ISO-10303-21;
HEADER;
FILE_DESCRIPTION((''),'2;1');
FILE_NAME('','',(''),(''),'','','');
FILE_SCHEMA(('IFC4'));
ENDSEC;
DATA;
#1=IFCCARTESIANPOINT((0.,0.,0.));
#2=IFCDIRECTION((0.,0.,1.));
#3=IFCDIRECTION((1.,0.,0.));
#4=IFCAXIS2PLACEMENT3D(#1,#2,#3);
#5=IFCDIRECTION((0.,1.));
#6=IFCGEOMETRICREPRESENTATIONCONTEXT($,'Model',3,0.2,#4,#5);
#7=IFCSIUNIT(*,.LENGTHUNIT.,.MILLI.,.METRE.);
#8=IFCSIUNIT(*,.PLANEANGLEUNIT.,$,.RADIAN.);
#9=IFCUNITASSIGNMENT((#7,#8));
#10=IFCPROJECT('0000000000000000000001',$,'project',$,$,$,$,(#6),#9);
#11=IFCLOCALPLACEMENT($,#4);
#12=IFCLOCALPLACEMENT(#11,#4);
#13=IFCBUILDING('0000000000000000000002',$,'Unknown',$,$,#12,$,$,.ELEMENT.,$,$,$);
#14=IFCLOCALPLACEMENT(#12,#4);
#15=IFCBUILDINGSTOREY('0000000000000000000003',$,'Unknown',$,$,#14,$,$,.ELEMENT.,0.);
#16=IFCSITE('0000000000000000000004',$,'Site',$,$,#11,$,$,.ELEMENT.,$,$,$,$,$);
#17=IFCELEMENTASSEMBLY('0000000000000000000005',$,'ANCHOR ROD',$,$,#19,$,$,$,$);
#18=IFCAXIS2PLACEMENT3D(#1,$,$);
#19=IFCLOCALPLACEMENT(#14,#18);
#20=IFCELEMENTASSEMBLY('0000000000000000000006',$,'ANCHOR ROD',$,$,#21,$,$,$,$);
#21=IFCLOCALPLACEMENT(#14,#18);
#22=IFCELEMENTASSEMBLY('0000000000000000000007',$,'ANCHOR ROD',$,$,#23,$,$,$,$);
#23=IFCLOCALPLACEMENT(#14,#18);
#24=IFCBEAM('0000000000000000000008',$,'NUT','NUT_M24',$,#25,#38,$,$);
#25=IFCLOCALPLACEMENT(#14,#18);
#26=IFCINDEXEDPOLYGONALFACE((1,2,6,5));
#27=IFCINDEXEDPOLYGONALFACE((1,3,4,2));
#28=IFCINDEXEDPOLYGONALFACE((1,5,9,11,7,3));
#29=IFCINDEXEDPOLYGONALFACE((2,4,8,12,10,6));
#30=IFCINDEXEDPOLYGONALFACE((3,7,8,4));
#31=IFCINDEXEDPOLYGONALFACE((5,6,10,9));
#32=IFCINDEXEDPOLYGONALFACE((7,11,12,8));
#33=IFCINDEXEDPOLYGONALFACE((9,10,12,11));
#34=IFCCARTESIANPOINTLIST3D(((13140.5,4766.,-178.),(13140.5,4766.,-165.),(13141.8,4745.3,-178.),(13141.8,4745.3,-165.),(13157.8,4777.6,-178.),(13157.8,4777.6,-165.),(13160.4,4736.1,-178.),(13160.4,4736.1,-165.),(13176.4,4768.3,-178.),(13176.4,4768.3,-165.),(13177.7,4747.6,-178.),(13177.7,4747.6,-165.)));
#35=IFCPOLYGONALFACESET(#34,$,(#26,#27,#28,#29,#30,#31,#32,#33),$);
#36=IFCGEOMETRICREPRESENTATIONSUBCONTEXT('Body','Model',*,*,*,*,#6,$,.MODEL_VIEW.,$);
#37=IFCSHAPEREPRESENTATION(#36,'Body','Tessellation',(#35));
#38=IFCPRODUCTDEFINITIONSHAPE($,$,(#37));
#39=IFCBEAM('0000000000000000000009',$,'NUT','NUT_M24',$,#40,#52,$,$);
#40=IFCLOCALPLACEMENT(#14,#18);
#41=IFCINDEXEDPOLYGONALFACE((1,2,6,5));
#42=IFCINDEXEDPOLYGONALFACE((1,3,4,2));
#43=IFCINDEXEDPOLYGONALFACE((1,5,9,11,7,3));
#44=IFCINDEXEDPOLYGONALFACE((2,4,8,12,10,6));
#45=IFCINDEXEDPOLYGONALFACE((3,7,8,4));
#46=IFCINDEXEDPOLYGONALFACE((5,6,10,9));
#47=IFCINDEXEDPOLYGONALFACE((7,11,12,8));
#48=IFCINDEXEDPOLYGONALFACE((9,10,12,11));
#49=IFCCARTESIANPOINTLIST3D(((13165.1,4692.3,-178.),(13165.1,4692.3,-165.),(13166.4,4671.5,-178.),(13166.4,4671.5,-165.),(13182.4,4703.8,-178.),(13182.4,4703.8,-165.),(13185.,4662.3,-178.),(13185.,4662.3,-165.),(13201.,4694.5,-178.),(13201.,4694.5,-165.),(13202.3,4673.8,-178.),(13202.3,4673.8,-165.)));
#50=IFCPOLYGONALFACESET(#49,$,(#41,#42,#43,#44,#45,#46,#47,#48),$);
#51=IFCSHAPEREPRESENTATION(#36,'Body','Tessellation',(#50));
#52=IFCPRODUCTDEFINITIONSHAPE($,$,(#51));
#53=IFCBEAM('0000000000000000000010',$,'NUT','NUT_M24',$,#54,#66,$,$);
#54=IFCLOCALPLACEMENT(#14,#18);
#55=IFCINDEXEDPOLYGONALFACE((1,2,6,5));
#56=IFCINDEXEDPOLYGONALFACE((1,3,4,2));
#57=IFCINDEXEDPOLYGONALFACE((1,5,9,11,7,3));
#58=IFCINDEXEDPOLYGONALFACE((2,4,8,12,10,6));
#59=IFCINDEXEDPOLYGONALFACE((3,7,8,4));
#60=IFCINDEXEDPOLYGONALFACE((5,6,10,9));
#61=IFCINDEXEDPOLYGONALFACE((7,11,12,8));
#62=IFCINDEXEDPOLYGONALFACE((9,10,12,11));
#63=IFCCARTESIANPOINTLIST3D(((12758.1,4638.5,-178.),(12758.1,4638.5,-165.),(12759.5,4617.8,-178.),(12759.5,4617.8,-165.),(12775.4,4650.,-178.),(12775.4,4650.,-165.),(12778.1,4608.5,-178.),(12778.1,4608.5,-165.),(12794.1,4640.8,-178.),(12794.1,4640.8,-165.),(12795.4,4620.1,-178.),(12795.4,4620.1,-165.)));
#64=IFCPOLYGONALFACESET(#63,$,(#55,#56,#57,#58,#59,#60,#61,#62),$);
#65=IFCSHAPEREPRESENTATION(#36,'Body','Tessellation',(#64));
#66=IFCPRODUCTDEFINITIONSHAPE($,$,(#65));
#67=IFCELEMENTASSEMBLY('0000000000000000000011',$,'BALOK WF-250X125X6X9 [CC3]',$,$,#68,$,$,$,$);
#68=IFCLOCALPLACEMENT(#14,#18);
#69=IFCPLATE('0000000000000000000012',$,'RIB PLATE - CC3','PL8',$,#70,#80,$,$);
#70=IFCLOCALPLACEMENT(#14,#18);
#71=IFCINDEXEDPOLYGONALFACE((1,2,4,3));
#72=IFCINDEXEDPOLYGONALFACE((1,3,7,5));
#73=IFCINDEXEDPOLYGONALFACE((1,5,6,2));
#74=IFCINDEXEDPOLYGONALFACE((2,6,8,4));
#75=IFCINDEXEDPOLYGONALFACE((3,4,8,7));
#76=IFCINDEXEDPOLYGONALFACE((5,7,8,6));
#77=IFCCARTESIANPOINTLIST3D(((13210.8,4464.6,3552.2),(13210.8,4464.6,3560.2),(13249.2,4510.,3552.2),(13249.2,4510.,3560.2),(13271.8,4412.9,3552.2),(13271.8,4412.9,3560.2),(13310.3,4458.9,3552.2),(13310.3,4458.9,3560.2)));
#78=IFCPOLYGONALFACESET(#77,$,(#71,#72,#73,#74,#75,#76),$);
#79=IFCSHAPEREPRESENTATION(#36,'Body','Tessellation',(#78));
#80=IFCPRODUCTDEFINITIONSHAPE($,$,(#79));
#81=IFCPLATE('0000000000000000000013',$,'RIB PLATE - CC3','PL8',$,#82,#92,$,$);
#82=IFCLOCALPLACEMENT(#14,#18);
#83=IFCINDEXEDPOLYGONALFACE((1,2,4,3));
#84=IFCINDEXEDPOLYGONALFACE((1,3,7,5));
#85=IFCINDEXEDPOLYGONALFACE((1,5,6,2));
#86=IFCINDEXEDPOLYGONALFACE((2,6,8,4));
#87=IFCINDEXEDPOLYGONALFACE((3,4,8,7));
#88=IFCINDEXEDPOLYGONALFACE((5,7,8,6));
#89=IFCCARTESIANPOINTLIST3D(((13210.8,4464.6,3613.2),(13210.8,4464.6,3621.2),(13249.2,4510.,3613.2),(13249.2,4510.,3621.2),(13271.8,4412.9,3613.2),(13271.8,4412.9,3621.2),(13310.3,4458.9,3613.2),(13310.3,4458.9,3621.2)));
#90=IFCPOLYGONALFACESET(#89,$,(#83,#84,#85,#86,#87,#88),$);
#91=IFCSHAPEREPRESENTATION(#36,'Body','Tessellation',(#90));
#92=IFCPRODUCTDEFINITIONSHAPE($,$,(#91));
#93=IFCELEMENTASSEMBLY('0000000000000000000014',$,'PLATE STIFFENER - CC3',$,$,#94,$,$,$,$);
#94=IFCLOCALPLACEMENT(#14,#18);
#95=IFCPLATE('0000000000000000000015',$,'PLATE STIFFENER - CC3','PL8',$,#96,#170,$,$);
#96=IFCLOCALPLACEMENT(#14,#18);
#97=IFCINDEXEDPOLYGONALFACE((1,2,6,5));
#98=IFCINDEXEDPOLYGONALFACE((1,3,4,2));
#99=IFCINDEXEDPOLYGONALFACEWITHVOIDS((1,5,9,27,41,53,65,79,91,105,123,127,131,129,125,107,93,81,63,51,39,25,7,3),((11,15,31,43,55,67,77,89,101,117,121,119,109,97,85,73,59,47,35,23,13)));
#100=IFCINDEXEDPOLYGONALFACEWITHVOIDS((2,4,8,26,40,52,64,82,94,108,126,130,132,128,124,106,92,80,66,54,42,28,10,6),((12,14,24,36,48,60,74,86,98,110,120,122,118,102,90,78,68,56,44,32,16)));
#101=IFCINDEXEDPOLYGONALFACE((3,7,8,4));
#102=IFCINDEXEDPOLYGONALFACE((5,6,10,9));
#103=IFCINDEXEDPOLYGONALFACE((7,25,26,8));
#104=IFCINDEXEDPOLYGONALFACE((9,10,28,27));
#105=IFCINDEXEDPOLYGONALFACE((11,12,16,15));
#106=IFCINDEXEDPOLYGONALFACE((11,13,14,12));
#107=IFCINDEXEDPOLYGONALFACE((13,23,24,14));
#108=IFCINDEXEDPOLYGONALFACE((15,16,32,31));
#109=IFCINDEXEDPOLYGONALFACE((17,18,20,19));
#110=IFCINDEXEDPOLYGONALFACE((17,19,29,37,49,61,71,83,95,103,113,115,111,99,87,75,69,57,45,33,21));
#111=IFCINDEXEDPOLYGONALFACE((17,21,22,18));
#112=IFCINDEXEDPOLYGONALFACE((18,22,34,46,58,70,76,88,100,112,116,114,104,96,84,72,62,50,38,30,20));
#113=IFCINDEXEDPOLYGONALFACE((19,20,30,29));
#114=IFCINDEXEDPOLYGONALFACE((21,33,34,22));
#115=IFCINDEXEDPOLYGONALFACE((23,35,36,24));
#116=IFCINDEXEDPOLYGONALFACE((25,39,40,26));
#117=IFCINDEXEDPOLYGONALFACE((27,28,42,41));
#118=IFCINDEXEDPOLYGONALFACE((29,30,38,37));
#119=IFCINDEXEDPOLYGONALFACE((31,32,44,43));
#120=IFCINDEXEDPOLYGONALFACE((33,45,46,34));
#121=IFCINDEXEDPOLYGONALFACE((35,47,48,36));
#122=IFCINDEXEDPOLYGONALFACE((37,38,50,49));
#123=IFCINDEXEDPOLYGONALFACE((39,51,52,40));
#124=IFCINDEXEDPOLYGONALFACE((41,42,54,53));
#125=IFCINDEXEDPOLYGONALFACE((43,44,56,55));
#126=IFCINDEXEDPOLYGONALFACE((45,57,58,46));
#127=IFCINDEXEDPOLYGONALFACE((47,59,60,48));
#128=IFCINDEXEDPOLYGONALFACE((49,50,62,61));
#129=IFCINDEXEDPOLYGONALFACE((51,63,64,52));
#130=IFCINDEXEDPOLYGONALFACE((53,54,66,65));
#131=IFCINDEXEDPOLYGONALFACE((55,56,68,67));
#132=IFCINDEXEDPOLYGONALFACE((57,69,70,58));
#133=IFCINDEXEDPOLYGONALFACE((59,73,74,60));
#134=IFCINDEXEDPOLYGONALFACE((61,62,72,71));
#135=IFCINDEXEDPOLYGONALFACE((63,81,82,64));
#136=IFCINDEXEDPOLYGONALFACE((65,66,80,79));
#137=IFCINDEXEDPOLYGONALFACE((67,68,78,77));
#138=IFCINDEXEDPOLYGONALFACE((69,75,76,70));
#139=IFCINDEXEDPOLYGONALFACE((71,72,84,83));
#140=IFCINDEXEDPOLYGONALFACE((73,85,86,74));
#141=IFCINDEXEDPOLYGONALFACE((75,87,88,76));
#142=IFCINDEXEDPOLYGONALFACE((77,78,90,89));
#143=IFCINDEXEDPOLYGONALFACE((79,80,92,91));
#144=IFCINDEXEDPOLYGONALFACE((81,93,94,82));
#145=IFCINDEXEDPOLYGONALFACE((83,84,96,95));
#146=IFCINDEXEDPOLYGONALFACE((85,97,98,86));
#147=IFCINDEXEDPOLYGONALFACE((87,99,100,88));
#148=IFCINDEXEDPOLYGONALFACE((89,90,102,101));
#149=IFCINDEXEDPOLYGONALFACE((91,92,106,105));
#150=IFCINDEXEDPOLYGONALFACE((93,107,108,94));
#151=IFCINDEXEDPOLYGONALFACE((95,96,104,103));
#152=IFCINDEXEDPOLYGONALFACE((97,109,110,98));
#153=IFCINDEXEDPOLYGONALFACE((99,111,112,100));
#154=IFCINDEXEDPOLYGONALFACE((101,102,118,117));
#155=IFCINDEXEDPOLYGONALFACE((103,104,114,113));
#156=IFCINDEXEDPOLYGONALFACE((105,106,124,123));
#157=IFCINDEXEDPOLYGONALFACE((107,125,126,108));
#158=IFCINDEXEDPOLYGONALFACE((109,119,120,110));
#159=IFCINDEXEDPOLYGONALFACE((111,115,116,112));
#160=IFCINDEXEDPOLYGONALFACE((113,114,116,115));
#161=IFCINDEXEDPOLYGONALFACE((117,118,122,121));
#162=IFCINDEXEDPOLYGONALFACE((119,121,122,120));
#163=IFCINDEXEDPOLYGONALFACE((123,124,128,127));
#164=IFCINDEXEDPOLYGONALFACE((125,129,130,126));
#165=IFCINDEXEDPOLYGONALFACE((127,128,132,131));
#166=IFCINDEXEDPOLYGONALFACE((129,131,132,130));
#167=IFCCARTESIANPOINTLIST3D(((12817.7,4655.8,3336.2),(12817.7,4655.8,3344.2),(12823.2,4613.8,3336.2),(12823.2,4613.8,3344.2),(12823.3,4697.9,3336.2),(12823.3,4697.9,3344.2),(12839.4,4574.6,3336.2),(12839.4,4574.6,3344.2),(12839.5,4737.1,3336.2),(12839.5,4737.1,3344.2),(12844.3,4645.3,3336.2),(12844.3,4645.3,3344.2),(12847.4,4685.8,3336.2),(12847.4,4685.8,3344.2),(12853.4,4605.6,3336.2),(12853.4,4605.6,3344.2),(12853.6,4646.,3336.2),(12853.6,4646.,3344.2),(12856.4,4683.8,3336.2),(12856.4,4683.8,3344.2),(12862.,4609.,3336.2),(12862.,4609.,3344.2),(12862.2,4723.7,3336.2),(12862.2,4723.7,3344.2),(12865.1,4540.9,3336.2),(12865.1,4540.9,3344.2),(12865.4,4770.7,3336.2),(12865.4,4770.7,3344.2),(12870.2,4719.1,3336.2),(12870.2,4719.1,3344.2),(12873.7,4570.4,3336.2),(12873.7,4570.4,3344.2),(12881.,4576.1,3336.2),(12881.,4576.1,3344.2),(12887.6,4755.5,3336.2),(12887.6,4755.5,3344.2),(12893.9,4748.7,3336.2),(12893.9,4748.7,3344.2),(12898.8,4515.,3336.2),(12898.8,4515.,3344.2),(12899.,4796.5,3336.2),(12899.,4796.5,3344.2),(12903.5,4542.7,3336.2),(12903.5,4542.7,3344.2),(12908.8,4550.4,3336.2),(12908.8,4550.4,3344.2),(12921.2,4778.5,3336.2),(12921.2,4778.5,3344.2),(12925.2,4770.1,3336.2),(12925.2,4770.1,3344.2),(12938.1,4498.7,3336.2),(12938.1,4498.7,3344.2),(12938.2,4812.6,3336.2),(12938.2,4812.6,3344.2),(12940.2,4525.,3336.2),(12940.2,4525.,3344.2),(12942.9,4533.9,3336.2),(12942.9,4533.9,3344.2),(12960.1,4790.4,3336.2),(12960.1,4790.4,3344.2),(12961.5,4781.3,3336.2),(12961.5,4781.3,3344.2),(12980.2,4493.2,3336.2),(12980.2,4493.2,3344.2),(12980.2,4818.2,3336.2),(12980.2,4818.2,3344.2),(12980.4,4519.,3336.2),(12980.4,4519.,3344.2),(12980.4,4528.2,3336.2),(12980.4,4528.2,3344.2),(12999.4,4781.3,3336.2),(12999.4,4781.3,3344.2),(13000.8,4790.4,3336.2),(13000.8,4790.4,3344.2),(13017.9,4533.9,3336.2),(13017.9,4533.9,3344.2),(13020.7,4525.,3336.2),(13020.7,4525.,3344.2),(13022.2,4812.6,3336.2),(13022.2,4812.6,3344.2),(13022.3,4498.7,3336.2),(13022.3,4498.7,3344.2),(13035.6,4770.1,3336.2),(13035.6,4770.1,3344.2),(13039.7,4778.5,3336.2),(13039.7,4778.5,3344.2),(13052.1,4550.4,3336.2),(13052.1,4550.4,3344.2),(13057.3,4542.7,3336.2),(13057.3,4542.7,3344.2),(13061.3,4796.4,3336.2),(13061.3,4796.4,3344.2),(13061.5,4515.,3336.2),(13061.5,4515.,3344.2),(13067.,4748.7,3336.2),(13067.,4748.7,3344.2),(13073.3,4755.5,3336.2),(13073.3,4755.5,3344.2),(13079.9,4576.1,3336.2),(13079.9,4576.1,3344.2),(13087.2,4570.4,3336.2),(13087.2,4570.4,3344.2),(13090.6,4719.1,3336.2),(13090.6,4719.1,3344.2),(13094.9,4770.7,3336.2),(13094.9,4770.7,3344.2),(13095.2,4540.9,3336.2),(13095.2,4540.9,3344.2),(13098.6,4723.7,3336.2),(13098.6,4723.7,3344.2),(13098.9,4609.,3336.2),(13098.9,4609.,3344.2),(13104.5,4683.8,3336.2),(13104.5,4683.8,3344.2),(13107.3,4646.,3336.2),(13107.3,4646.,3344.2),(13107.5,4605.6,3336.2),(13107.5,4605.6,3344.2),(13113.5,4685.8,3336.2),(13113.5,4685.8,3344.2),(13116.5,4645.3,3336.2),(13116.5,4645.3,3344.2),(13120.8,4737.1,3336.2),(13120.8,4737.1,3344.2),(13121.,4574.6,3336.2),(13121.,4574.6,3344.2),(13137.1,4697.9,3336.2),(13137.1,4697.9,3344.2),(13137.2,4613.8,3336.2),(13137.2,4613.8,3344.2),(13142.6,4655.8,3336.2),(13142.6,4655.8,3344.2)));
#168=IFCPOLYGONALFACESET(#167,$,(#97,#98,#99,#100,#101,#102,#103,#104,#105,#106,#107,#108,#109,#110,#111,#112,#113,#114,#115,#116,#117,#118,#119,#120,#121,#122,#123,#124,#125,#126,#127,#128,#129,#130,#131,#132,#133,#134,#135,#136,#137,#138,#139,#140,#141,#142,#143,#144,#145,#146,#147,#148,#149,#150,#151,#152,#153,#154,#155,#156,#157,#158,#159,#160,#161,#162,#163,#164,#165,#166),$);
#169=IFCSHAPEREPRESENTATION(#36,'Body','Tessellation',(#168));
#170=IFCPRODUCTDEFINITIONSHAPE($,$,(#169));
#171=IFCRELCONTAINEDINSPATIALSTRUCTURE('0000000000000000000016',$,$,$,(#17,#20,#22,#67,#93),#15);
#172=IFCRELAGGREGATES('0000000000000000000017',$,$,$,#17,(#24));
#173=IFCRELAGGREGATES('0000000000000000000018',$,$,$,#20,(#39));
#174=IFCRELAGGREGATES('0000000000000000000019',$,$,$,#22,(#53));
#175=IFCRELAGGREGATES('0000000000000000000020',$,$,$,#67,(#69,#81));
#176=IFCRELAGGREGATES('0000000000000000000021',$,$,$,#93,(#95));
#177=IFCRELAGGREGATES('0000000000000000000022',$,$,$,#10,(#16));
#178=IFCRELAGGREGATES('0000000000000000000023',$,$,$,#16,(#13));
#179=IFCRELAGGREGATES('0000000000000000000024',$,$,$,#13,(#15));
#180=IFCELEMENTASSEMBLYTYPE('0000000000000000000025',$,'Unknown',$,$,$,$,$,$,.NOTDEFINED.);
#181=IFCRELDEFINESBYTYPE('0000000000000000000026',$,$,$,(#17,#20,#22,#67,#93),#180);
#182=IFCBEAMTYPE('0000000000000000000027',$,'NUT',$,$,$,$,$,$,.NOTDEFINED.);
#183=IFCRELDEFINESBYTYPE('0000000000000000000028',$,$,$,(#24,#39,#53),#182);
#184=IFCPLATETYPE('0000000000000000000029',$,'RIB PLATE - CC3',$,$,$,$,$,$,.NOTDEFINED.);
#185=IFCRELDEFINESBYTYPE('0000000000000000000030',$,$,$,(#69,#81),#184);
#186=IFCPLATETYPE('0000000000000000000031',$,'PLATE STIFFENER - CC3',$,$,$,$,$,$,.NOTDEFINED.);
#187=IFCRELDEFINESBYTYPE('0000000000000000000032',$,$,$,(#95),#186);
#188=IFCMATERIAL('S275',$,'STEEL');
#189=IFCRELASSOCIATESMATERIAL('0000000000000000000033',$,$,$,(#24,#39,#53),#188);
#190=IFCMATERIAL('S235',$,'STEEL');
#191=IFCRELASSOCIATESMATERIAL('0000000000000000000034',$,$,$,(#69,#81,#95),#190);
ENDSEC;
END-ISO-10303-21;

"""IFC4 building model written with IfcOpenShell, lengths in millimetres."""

from ifc_helpers import new_model, si_unit, direction, frame, origin_with_axes, origin_2d_with_axis, place, context, subcontext, project, spatial, polyline, line, arc, indexed_curve, hollow_circle, outline, extrude, clip, halfspace, material, material_profile, profile_set, profile_usage, type_object, element, aggregate, save


model = new_model("IFC4")

# Units and contexts
model_context = context("Model", 3, precision=0.2, world=origin_with_axes(), true_north=direction((0.0, 1.0)))
body_context = subcontext(model_context, "Body", "Model", "MODEL_VIEW")
ifc_project = project(units=[si_unit("LENGTHUNIT", "METRE", prefix="MILLI"), si_unit("PLANEANGLEUNIT", "RADIAN")], contexts=[model_context])

# Site, building, storey
site_placement = place(None, origin_with_axes())
site = spatial("IfcSite", under=ifc_project, at=site_placement, Name="Site", CompositionType="ELEMENT")
building_placement = place(site_placement, origin_with_axes())
building = spatial("IfcBuilding", under=site, at=building_placement, Name="Unknown", CompositionType="ELEMENT")
storey_placement = place(building_placement, origin_with_axes())
storey = spatial("IfcBuildingStorey", under=building, at=storey_placement, Name="Unknown", CompositionType="ELEMENT", Elevation=0.0)

# Element assemblies
element_assembly_type = type_object("IfcElementAssemblyType", Name="Unknown", PredefinedType="NOTDEFINED")
ifc_material_1 = material(Name="S275", Category="STEEL")
assembly_1_placement = place(storey_placement, frame((13159.1, 4756.8, -151.0), z_axis=(0.447007, 0.894531, 0.0), x_axis=(0.0, 0.0, -1.0)))
assembly_1 = element("IfcElementAssembly", 1, at=assembly_1_placement, inside=storey, type_object=element_assembly_type, Name="ANCHOR ROD")
assembly_2_placement = place(storey_placement, frame((13183.7, 4683.0, -151.0), z_axis=(0.447007, 0.894531, 0.0), x_axis=(0.0, 0.0, -1.0)))
assembly_2 = element("IfcElementAssembly", 2, at=assembly_2_placement, inside=storey, type_object=element_assembly_type, Name="ANCHOR ROD")
assembly_3_placement = place(storey_placement, frame((12776.8, 4629.3, -151.0), z_axis=(-0.447007, -0.894531, 0.0), x_axis=(0.0, 0.0, -1.0)))
assembly_3 = element("IfcElementAssembly", 3, at=assembly_3_placement, inside=storey, type_object=element_assembly_type, Name="ANCHOR ROD")

# Beams
ifc_material_profile_1 = material_profile(ifc_material_1, outline(polyline([(18.0, 10.4), (0.0, 20.8), (-18.0, 10.4), (-18.0, -10.4), (0.0, -20.8), (18.0, -10.4), (18.0, 10.4)])), Name="NUT_M24")
ifc_profile_set_1 = profile_set([ifc_material_profile_1])
ifc_profile_usage_1 = profile_usage(ifc_profile_set_1, cardinal=5)
beam_type_1 = type_object("IfcBeamType", Name="NUT", PredefinedType="NOTDEFINED")
beam_1_placement = place(assembly_1_placement, frame((14.0, 0.0, 0.0), z_axis=(0.0, 0.003454, 0.999994), x_axis=(1.0, 0.0, 0.0)))
beam_1 = element("IfcBeam", 4, at=beam_1_placement, type_object=beam_type_1, material=ifc_profile_usage_1, Name="NUT", Description="NUT_M24", context=body_context, shape_type="SolidModel", body=[
    extrude(outline(polyline([(18.0, 10.4), (0.0, 20.8), (-18.0, 10.4), (-18.0, -10.4), (0.0, -20.8), (18.0, -10.4), (18.0, 10.4)])), frame((0.0, 0.0, 0.0), z_axis=(-1.0, 0.0, 0.0), x_axis=(0.0, 0.0, 1.0)), (0.0, 0.0, -1.0), 13.0),
])
aggregate(assembly_1, [beam_1])
beam_2_placement = place(assembly_2_placement, frame((14.0, 0.0, 0.0), z_axis=(0.0, 0.003454, 0.999994), x_axis=(1.0, 0.0, 0.0)))
beam_2 = element("IfcBeam", 5, at=beam_2_placement, type_object=beam_type_1, material=ifc_profile_usage_1, Name="NUT", Description="NUT_M24", context=body_context, shape_type="SolidModel", body=[
    extrude(outline(polyline([(18.0, 10.4), (0.0, 20.8), (-18.0, 10.4), (-18.0, -10.4), (0.0, -20.8), (18.0, -10.4), (18.0, 10.4)])), frame((0.0, 0.0, 0.0), z_axis=(-1.0, 0.0, 0.0), x_axis=(0.0, 0.0, 1.0)), (0.0, 0.0, -1.0), 13.0),
])
aggregate(assembly_2, [beam_2])
beam_3_placement = place(assembly_3_placement, frame((14.0, 0.0, 0.0), z_axis=(0.0, -0.003454, -0.999994), x_axis=(1.0, 0.0, 0.0)))
beam_3 = element("IfcBeam", 6, at=beam_3_placement, type_object=beam_type_1, material=ifc_profile_usage_1, Name="NUT", Description="NUT_M24", context=body_context, shape_type="SolidModel", body=[
    extrude(outline(polyline([(18.0, 10.4), (0.0, 20.8), (-18.0, 10.4), (-18.0, -10.4), (0.0, -20.8), (18.0, -10.4), (18.0, 10.4)])), frame((0.0, 0.0, 0.0), z_axis=(-1.0, 0.0, 0.0), x_axis=(0.0, 0.0, 1.0)), (0.0, 0.0, -1.0), 13.0),
])
aggregate(assembly_3, [beam_3])

# Element assembly, plates
ifc_material_2 = material(Name="S235", Category="STEEL")
assembly_4_placement = place(storey_placement, frame((13206.5, 4464.3, 3619.2), z_axis=(-0.646722, -0.762726, 0.0), x_axis=(0.762726, -0.646722, 0.0)))
assembly_4 = element("IfcElementAssembly", 7, at=assembly_4_placement, inside=storey, type_object=element_assembly_type, Name="BALOK WF-250X125X6X9 [CC3]")
ifc_material_profile_2 = material_profile(ifc_material_2, outline(indexed_curve([(0.0, 0.0), (80.0, 0.0), (79.6, 60.0), (0.0, 59.5)], segments=[line(1, 2, 3, 4, 1)])), Name="PL8")
ifc_profile_set_2 = profile_set([ifc_material_profile_2])
ifc_profile_usage_2 = profile_usage(ifc_profile_set_2, cardinal=5)
plate_type_1 = type_object("IfcPlateType", Name="RIB PLATE - CC3", PredefinedType="NOTDEFINED")
plate_1_placement = place(assembly_4_placement, frame((3.1, -63.0, -3.0), z_axis=(0.0, 1.0, 0.0), x_axis=(1.0, 0.0, 0.000042)))
plate_1 = element("IfcPlate", 8, at=plate_1_placement, type_object=plate_type_1, material=ifc_profile_usage_2, Name="RIB PLATE - CC3", Description="PL8", context=body_context, shape_type="SolidModel", body=[
    extrude(outline(indexed_curve([(0.0, 0.0), (80.0, 0.0), (79.6, 60.0), (0.0, 59.5)], segments=[line(1, 2, 3, 4, 1)])), frame((0.0, 0.0, 4.0), z_axis=(0.0, 0.0, 1.0), x_axis=(1.0, 0.0, 0.0)), (0.0, 0.0, -1.0), 8.0),
])
plate_2_placement = place(assembly_4_placement, frame((3.1, -2.0, -3.0), z_axis=(0.0, 1.0, 0.0), x_axis=(1.0, 0.0, 0.000042)))
plate_2 = element("IfcPlate", 9, at=plate_2_placement, type_object=plate_type_1, material=ifc_profile_usage_2, Name="RIB PLATE - CC3", Description="PL8", context=body_context, shape_type="SolidModel", body=[
    extrude(outline(indexed_curve([(0.0, 0.0), (80.0, 0.0), (79.6, 60.0), (0.0, 59.5)], segments=[line(1, 2, 3, 4, 1)])), frame((0.0, 0.0, 4.0), z_axis=(0.0, 0.0, 1.0), x_axis=(1.0, 0.0, 0.0)), (0.0, 0.0, -1.0), 8.0),
])
aggregate(assembly_4, [plate_1, plate_2])

# Element assembly, plate, opening
assembly_5_placement = place(storey_placement, frame((12980.2, 4818.2, 3340.2), z_axis=(0.0, 0.0, 1.0), x_axis=(-0.707888, -0.706325, 0.0)))
assembly_5 = element("IfcElementAssembly", 10, at=assembly_5_placement, inside=storey, type_object=element_assembly_type, Name="PLATE STIFFENER - CC3")
ifc_material_profile_3 = material_profile(ifc_material_2, outline(indexed_curve([(-47.7, 114.7), (0.0, 0.0), (114.8, -47.5), (229.7, 0.1), (277.3, 115.0), (229.6, 230.1), (114.4, 277.5), (-0.4, 229.7)], segments=[arc(1, 2, 3), arc(3, 4, 5), arc(5, 6, 7), arc(7, 8, 1)])), Name="PL8")
ifc_profile_set_3 = profile_set([ifc_material_profile_3])
ifc_profile_usage_3 = profile_usage(ifc_profile_set_3, cardinal=5)
plate_type_2 = type_object("IfcPlateType", Name="PLATE STIFFENER - CC3", PredefinedType="NOTDEFINED")
plate_3_placement = place(assembly_5_placement, origin_with_axes())
plate_3 = element("IfcPlate", 11, at=plate_3_placement, type_object=plate_type_2, material=ifc_profile_usage_3, Name="PLATE STIFFENER - CC3", Description="PL8", context=body_context, shape_type="SolidModel", body=[
    extrude(outline(indexed_curve([(-47.7, 114.7), (0.0, 0.0), (114.8, -47.5), (229.7, 0.1), (277.3, 115.0), (229.6, 230.1), (114.4, 277.5), (-0.4, 229.7)], segments=[arc(1, 2, 3), arc(3, 4, 5), arc(5, 6, 7), arc(7, 8, 1)])), frame((0.0, 0.0, 4.0), z_axis=(0.0, 0.0, 1.0), x_axis=(1.0, 0.0, 0.0)), (0.0, 0.0, -1.0), 8.0),
])
opening_placement = place(plate_3_placement, frame((114.7, 115.3, -3534.2), z_axis=(0.706325, 0.707888, 0.0), x_axis=(0.0, 0.0, 1.0)))
element("IfcOpeningElement", 12, at=opening_placement, cuts=plate_3, PredefinedType="OPENING", context=body_context, shape_type="Clipping", body=[
    clip(clip(extrude(hollow_circle(Radius=136.5, WallThickness=9.3, at=origin_2d_with_axis()), frame((-273.0, 0.0, 0.0), z_axis=(-1.0, 0.0, 0.0), x_axis=(0.0, 0.0, 1.0)), (0.0, 0.0, -1.0), 4211.2), halfspace(frame((-2.0, 0.2, -0.7), z_axis=(1.0, 0.0, 0.0), x_axis=(0.0, 0.894528, -0.447011)), True)), halfspace(frame((0.0, -110.7, -4.6), z_axis=(1.0, 0.0, 0.0), x_axis=(0.0, 0.952826, -0.303518)), True)),
])
aggregate(assembly_5, [plate_3])

save(model, "model.ifc")
